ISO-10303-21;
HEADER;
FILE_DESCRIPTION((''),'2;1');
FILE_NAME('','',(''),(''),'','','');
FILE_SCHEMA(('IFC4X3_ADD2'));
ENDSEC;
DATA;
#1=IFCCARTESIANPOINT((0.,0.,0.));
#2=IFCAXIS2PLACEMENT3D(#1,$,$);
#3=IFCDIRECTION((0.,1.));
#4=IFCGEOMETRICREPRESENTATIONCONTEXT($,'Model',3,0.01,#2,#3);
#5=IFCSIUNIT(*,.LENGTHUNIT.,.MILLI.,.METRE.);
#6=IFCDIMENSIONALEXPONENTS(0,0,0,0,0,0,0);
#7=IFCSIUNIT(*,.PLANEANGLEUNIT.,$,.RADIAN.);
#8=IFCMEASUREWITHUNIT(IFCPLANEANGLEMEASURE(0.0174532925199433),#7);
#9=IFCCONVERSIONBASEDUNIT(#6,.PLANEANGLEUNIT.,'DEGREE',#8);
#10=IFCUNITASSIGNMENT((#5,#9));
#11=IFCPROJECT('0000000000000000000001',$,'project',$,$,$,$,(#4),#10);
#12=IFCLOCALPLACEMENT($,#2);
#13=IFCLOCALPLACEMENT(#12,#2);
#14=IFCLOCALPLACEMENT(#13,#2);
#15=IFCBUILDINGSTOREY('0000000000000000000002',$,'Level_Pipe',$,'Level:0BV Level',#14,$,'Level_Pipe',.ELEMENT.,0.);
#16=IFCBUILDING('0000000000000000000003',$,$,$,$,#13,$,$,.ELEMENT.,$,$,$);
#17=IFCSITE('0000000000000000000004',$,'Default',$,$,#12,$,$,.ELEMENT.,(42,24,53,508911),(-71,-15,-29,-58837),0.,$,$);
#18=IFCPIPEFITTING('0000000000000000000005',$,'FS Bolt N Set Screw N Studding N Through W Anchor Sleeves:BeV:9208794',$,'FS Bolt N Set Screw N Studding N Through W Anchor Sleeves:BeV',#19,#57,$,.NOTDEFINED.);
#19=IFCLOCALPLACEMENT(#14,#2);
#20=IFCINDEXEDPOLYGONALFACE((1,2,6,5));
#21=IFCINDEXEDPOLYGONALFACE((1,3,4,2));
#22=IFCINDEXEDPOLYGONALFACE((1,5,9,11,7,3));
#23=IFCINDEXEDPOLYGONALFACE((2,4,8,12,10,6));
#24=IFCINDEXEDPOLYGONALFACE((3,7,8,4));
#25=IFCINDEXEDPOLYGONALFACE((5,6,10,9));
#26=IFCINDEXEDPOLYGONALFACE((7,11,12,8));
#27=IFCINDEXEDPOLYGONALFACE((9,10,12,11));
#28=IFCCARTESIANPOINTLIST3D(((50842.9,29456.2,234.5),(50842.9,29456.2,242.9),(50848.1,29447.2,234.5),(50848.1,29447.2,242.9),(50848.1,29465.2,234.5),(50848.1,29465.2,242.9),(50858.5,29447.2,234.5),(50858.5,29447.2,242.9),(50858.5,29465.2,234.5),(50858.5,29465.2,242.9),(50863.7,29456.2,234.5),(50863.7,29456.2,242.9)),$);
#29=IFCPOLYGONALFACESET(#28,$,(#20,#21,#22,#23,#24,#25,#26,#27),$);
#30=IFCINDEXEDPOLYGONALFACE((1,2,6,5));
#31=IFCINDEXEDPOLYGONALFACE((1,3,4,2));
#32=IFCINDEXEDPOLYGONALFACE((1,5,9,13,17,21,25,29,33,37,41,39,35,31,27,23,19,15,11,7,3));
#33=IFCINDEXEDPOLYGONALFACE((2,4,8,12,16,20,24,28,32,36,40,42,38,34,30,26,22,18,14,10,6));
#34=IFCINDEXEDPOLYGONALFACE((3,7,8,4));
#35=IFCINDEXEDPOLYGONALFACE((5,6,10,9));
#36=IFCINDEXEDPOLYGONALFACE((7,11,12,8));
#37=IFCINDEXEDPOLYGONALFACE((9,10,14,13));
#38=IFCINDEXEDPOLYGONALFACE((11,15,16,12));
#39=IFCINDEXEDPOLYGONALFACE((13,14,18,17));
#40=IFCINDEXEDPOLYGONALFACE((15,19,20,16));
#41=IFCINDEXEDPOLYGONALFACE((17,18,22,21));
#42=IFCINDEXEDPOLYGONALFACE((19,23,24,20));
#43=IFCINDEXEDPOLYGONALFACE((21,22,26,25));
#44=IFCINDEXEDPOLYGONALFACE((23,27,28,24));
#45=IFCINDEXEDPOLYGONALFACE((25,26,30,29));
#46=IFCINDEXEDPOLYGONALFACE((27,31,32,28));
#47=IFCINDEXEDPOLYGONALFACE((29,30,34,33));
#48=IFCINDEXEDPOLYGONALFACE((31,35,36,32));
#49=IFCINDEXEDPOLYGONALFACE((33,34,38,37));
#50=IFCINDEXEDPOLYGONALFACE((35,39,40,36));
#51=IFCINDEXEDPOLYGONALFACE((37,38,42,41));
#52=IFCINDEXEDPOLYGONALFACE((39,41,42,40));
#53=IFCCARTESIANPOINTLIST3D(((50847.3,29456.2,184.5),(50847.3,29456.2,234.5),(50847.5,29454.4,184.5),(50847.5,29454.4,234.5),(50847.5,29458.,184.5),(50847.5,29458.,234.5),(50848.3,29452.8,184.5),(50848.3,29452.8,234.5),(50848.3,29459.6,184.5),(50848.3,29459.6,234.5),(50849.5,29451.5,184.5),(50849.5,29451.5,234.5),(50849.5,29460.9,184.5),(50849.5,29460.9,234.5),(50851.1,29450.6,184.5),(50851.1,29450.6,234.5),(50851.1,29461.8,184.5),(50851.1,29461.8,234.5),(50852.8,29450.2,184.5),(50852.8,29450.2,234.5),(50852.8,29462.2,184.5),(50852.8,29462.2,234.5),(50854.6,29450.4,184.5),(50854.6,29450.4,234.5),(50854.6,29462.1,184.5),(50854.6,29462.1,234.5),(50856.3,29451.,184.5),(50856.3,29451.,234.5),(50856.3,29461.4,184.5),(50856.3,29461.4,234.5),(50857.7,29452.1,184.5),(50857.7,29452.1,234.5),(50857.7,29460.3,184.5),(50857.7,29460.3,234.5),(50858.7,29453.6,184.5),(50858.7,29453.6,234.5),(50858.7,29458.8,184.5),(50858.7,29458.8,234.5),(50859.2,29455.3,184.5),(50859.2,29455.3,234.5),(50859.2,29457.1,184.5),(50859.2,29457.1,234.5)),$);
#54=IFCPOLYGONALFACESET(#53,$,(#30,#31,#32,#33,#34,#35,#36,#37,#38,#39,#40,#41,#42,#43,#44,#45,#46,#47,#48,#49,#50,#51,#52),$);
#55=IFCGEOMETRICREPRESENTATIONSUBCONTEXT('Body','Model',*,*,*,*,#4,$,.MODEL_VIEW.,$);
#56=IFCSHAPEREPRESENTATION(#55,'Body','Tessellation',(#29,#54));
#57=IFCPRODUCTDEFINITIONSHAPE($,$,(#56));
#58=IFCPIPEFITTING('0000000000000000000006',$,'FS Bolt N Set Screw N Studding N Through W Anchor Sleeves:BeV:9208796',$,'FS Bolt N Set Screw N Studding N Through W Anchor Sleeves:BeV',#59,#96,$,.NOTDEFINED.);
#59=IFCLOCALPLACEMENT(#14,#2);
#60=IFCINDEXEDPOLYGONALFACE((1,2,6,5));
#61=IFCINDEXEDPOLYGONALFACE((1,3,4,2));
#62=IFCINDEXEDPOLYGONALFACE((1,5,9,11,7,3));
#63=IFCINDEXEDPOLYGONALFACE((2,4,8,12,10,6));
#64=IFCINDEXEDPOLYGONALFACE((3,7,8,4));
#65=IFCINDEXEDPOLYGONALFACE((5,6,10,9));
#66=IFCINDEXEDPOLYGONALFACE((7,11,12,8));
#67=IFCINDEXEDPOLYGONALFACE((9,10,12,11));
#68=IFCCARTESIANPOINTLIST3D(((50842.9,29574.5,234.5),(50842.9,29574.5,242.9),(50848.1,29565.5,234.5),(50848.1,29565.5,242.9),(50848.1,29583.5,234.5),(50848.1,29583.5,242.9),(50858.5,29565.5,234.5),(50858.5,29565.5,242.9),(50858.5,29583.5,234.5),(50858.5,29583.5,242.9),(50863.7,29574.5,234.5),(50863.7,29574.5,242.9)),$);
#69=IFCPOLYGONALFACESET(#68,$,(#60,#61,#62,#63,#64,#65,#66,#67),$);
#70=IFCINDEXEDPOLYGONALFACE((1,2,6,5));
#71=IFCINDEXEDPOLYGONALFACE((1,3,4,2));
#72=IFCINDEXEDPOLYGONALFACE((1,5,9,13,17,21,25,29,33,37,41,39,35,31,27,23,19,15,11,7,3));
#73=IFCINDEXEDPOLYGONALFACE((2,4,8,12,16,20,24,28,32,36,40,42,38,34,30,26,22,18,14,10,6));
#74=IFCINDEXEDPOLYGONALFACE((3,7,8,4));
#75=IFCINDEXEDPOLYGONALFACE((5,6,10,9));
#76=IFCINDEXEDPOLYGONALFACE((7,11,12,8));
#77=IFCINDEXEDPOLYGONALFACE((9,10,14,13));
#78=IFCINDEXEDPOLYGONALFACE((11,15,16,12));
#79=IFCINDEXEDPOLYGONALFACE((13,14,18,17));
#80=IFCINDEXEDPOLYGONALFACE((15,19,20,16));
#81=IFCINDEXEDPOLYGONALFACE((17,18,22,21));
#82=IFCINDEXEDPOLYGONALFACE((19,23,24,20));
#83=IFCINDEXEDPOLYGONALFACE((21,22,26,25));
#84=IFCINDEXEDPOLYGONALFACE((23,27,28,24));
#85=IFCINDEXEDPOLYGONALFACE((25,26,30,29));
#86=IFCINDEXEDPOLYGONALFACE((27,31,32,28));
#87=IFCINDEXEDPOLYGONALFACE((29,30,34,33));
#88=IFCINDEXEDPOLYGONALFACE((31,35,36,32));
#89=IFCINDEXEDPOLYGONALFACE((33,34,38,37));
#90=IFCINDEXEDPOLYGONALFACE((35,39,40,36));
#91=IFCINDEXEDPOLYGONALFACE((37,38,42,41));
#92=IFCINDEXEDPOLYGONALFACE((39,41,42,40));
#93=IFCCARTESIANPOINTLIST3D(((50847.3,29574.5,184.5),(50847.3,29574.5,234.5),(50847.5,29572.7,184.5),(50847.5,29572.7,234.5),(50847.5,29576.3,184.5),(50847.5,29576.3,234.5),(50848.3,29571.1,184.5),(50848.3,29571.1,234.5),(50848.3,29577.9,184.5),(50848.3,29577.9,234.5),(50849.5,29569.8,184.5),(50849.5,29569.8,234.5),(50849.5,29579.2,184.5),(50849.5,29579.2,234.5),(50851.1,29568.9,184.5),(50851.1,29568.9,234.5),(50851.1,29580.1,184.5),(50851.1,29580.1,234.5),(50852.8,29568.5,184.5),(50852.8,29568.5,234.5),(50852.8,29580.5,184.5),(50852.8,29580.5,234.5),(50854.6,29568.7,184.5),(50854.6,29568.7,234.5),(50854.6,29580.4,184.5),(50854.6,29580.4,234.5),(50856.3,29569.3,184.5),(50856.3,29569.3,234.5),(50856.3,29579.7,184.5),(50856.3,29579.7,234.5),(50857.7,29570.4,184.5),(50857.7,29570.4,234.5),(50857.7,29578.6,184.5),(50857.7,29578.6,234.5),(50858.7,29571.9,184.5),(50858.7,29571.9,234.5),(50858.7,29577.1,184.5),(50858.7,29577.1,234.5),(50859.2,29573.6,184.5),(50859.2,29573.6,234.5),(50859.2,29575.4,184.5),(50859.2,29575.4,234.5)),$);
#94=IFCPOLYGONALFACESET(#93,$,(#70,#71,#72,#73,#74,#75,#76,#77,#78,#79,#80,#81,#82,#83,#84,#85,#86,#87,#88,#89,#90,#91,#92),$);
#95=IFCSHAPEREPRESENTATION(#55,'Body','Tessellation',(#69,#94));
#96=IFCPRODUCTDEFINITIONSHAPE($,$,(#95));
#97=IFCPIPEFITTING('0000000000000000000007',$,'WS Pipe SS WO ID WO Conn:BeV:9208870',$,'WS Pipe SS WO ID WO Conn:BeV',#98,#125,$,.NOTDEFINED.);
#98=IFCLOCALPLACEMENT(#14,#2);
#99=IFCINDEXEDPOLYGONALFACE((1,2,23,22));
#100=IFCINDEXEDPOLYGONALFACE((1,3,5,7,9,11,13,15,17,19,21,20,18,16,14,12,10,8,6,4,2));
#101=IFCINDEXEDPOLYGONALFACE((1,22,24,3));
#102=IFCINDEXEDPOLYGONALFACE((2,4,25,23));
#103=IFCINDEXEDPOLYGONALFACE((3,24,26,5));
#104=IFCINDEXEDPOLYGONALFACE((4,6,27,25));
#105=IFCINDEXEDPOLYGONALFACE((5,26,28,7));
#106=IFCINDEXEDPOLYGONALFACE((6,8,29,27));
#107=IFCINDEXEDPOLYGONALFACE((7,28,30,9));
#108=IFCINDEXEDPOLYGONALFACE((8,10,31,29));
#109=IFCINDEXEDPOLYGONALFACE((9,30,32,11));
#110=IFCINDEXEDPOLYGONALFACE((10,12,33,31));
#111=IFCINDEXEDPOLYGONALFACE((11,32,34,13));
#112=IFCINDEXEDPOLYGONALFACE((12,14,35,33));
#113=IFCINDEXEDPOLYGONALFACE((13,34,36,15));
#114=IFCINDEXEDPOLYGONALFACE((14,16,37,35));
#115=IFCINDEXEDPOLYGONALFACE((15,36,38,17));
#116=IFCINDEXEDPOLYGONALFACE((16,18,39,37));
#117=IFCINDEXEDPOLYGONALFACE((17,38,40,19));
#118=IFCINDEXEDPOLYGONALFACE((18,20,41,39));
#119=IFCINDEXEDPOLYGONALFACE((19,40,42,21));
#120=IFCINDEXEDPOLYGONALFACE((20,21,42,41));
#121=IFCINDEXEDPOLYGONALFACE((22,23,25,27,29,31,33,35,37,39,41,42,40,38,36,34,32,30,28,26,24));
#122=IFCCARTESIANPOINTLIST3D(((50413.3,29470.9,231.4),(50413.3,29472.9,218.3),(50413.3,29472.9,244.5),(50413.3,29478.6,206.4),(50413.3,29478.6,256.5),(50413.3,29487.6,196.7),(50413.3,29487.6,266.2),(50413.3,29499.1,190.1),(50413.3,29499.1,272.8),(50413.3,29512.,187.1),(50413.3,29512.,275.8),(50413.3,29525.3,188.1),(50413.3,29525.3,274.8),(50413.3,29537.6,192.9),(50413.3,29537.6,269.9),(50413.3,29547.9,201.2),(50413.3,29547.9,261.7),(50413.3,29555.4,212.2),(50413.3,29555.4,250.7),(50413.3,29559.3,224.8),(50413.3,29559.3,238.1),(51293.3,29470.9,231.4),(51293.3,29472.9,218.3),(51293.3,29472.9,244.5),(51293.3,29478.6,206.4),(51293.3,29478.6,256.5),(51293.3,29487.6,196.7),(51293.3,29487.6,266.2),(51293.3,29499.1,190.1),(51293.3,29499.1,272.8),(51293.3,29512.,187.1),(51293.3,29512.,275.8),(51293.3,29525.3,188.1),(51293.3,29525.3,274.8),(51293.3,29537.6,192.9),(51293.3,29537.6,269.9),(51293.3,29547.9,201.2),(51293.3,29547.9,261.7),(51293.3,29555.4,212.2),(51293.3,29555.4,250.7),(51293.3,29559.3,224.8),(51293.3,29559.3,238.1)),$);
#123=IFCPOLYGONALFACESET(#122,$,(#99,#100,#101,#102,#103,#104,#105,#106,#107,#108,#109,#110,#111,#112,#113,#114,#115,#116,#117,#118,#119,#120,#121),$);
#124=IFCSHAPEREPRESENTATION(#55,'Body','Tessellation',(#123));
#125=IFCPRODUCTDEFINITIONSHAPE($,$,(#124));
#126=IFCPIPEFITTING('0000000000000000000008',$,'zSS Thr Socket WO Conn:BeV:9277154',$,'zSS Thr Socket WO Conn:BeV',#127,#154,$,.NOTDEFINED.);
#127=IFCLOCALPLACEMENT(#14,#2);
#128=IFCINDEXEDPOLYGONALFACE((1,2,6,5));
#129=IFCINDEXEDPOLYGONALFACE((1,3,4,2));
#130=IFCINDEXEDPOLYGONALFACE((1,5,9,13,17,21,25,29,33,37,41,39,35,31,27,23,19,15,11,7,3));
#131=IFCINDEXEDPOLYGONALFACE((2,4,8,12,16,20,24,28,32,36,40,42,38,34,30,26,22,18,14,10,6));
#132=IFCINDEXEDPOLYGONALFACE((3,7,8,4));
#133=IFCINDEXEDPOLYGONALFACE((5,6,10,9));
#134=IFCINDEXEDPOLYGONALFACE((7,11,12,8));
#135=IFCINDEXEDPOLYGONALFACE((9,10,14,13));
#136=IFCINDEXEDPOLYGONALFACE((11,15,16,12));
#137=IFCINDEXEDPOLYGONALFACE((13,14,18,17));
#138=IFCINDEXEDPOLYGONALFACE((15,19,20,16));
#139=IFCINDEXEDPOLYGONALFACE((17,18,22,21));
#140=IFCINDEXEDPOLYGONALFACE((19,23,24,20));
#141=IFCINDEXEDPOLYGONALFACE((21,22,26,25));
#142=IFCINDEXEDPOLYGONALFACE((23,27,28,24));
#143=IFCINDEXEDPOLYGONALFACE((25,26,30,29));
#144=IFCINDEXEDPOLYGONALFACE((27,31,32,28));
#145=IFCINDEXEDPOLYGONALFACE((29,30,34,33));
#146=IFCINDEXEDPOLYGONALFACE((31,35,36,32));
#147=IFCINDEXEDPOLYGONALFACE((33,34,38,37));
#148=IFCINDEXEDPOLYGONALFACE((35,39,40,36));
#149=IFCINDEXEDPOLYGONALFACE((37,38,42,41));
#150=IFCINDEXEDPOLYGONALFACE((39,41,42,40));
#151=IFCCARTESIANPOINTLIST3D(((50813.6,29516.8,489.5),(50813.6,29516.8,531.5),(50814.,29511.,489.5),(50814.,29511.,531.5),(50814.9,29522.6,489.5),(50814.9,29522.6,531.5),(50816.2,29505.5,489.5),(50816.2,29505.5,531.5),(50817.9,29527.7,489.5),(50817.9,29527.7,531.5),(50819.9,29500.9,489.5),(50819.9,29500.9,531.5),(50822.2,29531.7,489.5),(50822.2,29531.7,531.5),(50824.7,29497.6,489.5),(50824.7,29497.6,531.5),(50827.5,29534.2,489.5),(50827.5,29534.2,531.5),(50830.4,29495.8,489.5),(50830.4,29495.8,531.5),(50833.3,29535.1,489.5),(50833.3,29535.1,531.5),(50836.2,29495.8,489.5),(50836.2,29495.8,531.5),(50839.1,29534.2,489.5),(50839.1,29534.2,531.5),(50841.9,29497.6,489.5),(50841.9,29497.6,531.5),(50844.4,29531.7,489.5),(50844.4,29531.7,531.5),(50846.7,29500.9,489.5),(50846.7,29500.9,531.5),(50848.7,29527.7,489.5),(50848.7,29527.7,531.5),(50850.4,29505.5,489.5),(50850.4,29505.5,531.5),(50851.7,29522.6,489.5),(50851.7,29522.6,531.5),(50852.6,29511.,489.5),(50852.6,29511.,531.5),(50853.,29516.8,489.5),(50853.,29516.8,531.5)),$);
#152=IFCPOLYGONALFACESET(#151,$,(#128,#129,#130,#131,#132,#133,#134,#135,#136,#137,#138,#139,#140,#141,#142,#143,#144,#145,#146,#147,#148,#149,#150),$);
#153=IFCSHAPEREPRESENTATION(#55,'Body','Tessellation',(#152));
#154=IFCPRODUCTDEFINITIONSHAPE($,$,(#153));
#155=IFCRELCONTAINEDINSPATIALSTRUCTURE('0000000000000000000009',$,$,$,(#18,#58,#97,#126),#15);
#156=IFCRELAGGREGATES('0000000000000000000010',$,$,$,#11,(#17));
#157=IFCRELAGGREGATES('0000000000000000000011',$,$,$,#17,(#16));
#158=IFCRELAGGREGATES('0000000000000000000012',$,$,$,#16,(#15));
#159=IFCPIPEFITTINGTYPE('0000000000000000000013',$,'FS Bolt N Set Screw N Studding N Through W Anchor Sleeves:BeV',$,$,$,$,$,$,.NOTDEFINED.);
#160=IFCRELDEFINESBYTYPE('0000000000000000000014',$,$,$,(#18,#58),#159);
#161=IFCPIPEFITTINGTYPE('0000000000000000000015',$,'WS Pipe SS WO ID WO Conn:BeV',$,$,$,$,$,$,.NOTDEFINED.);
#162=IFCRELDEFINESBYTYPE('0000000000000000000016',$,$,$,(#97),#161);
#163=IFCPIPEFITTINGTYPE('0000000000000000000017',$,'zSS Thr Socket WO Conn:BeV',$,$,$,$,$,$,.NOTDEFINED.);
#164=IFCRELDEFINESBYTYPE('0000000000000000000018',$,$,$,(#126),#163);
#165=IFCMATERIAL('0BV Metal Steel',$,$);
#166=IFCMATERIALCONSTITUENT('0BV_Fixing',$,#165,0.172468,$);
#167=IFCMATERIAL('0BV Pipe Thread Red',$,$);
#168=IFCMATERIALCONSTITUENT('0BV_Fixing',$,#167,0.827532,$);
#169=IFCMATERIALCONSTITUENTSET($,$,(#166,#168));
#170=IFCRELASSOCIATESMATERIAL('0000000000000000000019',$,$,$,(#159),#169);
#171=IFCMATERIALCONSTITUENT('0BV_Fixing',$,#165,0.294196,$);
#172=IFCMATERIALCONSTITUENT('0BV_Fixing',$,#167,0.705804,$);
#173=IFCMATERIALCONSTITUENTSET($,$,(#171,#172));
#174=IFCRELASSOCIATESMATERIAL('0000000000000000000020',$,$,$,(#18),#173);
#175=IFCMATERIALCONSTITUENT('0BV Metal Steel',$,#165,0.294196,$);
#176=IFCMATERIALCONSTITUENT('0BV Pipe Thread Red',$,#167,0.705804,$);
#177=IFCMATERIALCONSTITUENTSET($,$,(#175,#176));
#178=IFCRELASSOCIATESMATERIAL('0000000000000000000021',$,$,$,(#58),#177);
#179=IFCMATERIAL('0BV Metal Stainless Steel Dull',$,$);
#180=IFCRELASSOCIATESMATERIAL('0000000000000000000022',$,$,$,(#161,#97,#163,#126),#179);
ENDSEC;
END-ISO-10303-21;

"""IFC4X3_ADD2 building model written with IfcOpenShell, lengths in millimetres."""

from ifc_helpers import new_model, entity, si_unit, converted_unit, direction, frame, frame_2d, origin, place, context, subcontext, project, spatial, polyline, circle, outline, extrude, source, transform, mapped, material, constituent, constituent_set, type_object, type_shapes, element, save


model = new_model("IFC4X3_ADD2")

# Units and contexts
model_context = context("Model", 3, precision=0.01, world=origin(), true_north=direction((0.0, 1.0)))
body_context = subcontext(model_context, "Body", "Model", "MODEL_VIEW")
ifc_project = project(units=[si_unit("LENGTHUNIT", "METRE", prefix="MILLI"), converted_unit("PLANEANGLEUNIT", "DEGREE", entity("IfcPlaneAngleMeasure", 0.0174532925199433), si_unit("PLANEANGLEUNIT", "RADIAN"), dimensions=[0, 0, 0, 0, 0, 0, 0])], contexts=[model_context])

# Site, building, storey
site_placement = place(None, origin())
site = spatial("IfcSite", under=ifc_project, at=site_placement, Name="Default", CompositionType="ELEMENT", RefLatitude=(42, 24, 53, 508911), RefLongitude=(-71, -15, -29, -58837), RefElevation=0.0)
building_placement = place(site_placement, origin())
building = spatial("IfcBuilding", under=site, at=building_placement, CompositionType="ELEMENT")
storey_placement = place(building_placement, origin())
storey = spatial("IfcBuildingStorey", under=building, at=storey_placement, Name="Level_Pipe", ObjectType="Level:0BV Level", LongName="Level_Pipe", CompositionType="ELEMENT", Elevation=0.0)

# Pipe fittings
ifc_material_1 = material(Name="0BV Metal Stainless Steel Dull")
ifc_material_2 = material(Name="0BV Metal Steel")
ifc_material_3 = material(Name="0BV Pipe Thread Red")
ifc_constituent_1 = constituent(ifc_material_2, Name="0BV_Fixing", fraction=0.294196)
ifc_constituent_2 = constituent(ifc_material_3, Name="0BV_Fixing", fraction=0.705804)
ifc_constituent_set_1 = constituent_set(constituents=[ifc_constituent_1, ifc_constituent_2])
ifc_constituent_3 = constituent(ifc_material_2, Name="0BV_Fixing", fraction=0.172468)
ifc_constituent_4 = constituent(ifc_material_3, Name="0BV_Fixing", fraction=0.827532)
ifc_constituent_set_2 = constituent_set(constituents=[ifc_constituent_3, ifc_constituent_4])
pipe_fitting_type_1 = type_object("IfcPipeFittingType", Name="FS Bolt N Set Screw N Studding N Through W Anchor Sleeves:BeV", PredefinedType="NOTDEFINED", material=ifc_constituent_set_2)
shared_shape_1 = source(origin(), body_context, "Body", "SweptSolid", [
    extrude(outline(polyline([(-5.2, -9.0), (5.2, -9.0), (10.4, 0.0), (5.2, 9.0), (-5.2, 9.0), (-10.4, 0.0), (-5.2, -9.0)])), frame((-8.4, 0.0, 0.0), z_axis=(1.0, 0.0, 0.0), x_axis=(0.0, -1.0, 0.0)), (0.0, 0.0, 1.0), 8.4),
    extrude(circle(Radius=6.0, at=frame_2d((0.0, 0.0), x_axis=(1.0, 0.0))), frame((0.0, 0.0, 0.0), z_axis=(1.0, 0.0, 0.0), x_axis=(0.0, -1.0, 0.0)), (0.0, 0.0, 1.0), 50.0),
])
type_shapes(pipe_fitting_type_1, [shared_shape_1])
pipe_fitting_1_placement = place(storey_placement, frame((50853.3, 29456.2, 234.5), z_axis=(0.0, -1.0, 0.0), x_axis=(0.0, 0.0, -1.0)))
element("IfcPipeFitting", 1, at=pipe_fitting_1_placement, inside=storey, type_object=pipe_fitting_type_1, material=ifc_constituent_set_1, Name="FS Bolt N Set Screw N Studding N Through W Anchor Sleeves:BeV:9208794", ObjectType="FS Bolt N Set Screw N Studding N Through W Anchor Sleeves:BeV", PredefinedType="NOTDEFINED", context=body_context, shape_type="MappedRepresentation", body=[
    mapped(shared_shape_1, transform((0.0, 0.0, 0.0), scale=1.0)),
])
ifc_constituent_5 = constituent(ifc_material_2, Name="0BV Metal Steel", fraction=0.294196)
ifc_constituent_6 = constituent(ifc_material_3, Name="0BV Pipe Thread Red", fraction=0.705804)
ifc_constituent_set_3 = constituent_set(constituents=[ifc_constituent_5, ifc_constituent_6])
pipe_fitting_2_placement = place(storey_placement, frame((50853.3, 29574.5, 234.5), z_axis=(0.0, -1.0, 0.0), x_axis=(0.0, 0.0, -1.0)))
element("IfcPipeFitting", 2, at=pipe_fitting_2_placement, inside=storey, type_object=pipe_fitting_type_1, material=ifc_constituent_set_3, Name="FS Bolt N Set Screw N Studding N Through W Anchor Sleeves:BeV:9208796", ObjectType="FS Bolt N Set Screw N Studding N Through W Anchor Sleeves:BeV", PredefinedType="NOTDEFINED", context=body_context, shape_type="MappedRepresentation", body=[
    mapped(shared_shape_1, transform((0.0, 0.0, 0.0), scale=1.0)),
])
pipe_fitting_type_2 = type_object("IfcPipeFittingType", Name="WS Pipe SS WO ID WO Conn:BeV", PredefinedType="NOTDEFINED", material=ifc_material_1)
shared_shape_2 = source(origin(), body_context, "Body", "SweptSolid", [
    extrude(circle(Radius=44.5, at=frame_2d((0.0, 0.0), x_axis=(1.0, 0.0))), frame((-440.0, 0.0, 0.0), z_axis=(1.0, 0.0, 0.0), x_axis=(0.0, 1.0, 0.0)), (0.0, 0.0, 1.0), 880.0),
])
type_shapes(pipe_fitting_type_2, [shared_shape_2])
pipe_fitting_3_placement = place(storey_placement, frame((50853.3, 29515.4, 231.4), z_axis=(0.0, 0.0, 1.0), x_axis=(-1.0, 0.0, 0.0)))
element("IfcPipeFitting", 3, at=pipe_fitting_3_placement, inside=storey, type_object=pipe_fitting_type_2, material=ifc_material_1, Name="WS Pipe SS WO ID WO Conn:BeV:9208870", ObjectType="WS Pipe SS WO ID WO Conn:BeV", PredefinedType="NOTDEFINED", context=body_context, shape_type="MappedRepresentation", body=[
    mapped(shared_shape_2, transform((0.0, 0.0, 0.0), scale=1.0)),
])
pipe_fitting_type_3 = type_object("IfcPipeFittingType", Name="zSS Thr Socket WO Conn:BeV", PredefinedType="NOTDEFINED", material=ifc_material_1)
shared_shape_3 = source(origin(), body_context, "Body", "SweptSolid", [
    extrude(circle(Radius=19.8, at=frame_2d((0.0, 0.0), x_axis=(1.0, 0.0))), frame((-21.0, 0.0, 0.0), z_axis=(1.0, 0.0, 0.0), x_axis=(0.0, 1.0, 0.0)), (0.0, 0.0, 1.0), 42.0),
])
type_shapes(pipe_fitting_type_3, [shared_shape_3])
pipe_fitting_4_placement = place(storey_placement, frame((50833.3, 29515.4, 510.5), z_axis=(1.0, 0.0, 0.0), x_axis=(0.0, 0.0, -1.0)))
element("IfcPipeFitting", 4, at=pipe_fitting_4_placement, inside=storey, type_object=pipe_fitting_type_3, material=ifc_material_1, Name="zSS Thr Socket WO Conn:BeV:9277154", ObjectType="zSS Thr Socket WO Conn:BeV", PredefinedType="NOTDEFINED", context=body_context, shape_type="MappedRepresentation", body=[
    mapped(shared_shape_3, transform((0.0, 0.0, 0.0), scale=1.0)),
])

save(model, "model.ifc")
